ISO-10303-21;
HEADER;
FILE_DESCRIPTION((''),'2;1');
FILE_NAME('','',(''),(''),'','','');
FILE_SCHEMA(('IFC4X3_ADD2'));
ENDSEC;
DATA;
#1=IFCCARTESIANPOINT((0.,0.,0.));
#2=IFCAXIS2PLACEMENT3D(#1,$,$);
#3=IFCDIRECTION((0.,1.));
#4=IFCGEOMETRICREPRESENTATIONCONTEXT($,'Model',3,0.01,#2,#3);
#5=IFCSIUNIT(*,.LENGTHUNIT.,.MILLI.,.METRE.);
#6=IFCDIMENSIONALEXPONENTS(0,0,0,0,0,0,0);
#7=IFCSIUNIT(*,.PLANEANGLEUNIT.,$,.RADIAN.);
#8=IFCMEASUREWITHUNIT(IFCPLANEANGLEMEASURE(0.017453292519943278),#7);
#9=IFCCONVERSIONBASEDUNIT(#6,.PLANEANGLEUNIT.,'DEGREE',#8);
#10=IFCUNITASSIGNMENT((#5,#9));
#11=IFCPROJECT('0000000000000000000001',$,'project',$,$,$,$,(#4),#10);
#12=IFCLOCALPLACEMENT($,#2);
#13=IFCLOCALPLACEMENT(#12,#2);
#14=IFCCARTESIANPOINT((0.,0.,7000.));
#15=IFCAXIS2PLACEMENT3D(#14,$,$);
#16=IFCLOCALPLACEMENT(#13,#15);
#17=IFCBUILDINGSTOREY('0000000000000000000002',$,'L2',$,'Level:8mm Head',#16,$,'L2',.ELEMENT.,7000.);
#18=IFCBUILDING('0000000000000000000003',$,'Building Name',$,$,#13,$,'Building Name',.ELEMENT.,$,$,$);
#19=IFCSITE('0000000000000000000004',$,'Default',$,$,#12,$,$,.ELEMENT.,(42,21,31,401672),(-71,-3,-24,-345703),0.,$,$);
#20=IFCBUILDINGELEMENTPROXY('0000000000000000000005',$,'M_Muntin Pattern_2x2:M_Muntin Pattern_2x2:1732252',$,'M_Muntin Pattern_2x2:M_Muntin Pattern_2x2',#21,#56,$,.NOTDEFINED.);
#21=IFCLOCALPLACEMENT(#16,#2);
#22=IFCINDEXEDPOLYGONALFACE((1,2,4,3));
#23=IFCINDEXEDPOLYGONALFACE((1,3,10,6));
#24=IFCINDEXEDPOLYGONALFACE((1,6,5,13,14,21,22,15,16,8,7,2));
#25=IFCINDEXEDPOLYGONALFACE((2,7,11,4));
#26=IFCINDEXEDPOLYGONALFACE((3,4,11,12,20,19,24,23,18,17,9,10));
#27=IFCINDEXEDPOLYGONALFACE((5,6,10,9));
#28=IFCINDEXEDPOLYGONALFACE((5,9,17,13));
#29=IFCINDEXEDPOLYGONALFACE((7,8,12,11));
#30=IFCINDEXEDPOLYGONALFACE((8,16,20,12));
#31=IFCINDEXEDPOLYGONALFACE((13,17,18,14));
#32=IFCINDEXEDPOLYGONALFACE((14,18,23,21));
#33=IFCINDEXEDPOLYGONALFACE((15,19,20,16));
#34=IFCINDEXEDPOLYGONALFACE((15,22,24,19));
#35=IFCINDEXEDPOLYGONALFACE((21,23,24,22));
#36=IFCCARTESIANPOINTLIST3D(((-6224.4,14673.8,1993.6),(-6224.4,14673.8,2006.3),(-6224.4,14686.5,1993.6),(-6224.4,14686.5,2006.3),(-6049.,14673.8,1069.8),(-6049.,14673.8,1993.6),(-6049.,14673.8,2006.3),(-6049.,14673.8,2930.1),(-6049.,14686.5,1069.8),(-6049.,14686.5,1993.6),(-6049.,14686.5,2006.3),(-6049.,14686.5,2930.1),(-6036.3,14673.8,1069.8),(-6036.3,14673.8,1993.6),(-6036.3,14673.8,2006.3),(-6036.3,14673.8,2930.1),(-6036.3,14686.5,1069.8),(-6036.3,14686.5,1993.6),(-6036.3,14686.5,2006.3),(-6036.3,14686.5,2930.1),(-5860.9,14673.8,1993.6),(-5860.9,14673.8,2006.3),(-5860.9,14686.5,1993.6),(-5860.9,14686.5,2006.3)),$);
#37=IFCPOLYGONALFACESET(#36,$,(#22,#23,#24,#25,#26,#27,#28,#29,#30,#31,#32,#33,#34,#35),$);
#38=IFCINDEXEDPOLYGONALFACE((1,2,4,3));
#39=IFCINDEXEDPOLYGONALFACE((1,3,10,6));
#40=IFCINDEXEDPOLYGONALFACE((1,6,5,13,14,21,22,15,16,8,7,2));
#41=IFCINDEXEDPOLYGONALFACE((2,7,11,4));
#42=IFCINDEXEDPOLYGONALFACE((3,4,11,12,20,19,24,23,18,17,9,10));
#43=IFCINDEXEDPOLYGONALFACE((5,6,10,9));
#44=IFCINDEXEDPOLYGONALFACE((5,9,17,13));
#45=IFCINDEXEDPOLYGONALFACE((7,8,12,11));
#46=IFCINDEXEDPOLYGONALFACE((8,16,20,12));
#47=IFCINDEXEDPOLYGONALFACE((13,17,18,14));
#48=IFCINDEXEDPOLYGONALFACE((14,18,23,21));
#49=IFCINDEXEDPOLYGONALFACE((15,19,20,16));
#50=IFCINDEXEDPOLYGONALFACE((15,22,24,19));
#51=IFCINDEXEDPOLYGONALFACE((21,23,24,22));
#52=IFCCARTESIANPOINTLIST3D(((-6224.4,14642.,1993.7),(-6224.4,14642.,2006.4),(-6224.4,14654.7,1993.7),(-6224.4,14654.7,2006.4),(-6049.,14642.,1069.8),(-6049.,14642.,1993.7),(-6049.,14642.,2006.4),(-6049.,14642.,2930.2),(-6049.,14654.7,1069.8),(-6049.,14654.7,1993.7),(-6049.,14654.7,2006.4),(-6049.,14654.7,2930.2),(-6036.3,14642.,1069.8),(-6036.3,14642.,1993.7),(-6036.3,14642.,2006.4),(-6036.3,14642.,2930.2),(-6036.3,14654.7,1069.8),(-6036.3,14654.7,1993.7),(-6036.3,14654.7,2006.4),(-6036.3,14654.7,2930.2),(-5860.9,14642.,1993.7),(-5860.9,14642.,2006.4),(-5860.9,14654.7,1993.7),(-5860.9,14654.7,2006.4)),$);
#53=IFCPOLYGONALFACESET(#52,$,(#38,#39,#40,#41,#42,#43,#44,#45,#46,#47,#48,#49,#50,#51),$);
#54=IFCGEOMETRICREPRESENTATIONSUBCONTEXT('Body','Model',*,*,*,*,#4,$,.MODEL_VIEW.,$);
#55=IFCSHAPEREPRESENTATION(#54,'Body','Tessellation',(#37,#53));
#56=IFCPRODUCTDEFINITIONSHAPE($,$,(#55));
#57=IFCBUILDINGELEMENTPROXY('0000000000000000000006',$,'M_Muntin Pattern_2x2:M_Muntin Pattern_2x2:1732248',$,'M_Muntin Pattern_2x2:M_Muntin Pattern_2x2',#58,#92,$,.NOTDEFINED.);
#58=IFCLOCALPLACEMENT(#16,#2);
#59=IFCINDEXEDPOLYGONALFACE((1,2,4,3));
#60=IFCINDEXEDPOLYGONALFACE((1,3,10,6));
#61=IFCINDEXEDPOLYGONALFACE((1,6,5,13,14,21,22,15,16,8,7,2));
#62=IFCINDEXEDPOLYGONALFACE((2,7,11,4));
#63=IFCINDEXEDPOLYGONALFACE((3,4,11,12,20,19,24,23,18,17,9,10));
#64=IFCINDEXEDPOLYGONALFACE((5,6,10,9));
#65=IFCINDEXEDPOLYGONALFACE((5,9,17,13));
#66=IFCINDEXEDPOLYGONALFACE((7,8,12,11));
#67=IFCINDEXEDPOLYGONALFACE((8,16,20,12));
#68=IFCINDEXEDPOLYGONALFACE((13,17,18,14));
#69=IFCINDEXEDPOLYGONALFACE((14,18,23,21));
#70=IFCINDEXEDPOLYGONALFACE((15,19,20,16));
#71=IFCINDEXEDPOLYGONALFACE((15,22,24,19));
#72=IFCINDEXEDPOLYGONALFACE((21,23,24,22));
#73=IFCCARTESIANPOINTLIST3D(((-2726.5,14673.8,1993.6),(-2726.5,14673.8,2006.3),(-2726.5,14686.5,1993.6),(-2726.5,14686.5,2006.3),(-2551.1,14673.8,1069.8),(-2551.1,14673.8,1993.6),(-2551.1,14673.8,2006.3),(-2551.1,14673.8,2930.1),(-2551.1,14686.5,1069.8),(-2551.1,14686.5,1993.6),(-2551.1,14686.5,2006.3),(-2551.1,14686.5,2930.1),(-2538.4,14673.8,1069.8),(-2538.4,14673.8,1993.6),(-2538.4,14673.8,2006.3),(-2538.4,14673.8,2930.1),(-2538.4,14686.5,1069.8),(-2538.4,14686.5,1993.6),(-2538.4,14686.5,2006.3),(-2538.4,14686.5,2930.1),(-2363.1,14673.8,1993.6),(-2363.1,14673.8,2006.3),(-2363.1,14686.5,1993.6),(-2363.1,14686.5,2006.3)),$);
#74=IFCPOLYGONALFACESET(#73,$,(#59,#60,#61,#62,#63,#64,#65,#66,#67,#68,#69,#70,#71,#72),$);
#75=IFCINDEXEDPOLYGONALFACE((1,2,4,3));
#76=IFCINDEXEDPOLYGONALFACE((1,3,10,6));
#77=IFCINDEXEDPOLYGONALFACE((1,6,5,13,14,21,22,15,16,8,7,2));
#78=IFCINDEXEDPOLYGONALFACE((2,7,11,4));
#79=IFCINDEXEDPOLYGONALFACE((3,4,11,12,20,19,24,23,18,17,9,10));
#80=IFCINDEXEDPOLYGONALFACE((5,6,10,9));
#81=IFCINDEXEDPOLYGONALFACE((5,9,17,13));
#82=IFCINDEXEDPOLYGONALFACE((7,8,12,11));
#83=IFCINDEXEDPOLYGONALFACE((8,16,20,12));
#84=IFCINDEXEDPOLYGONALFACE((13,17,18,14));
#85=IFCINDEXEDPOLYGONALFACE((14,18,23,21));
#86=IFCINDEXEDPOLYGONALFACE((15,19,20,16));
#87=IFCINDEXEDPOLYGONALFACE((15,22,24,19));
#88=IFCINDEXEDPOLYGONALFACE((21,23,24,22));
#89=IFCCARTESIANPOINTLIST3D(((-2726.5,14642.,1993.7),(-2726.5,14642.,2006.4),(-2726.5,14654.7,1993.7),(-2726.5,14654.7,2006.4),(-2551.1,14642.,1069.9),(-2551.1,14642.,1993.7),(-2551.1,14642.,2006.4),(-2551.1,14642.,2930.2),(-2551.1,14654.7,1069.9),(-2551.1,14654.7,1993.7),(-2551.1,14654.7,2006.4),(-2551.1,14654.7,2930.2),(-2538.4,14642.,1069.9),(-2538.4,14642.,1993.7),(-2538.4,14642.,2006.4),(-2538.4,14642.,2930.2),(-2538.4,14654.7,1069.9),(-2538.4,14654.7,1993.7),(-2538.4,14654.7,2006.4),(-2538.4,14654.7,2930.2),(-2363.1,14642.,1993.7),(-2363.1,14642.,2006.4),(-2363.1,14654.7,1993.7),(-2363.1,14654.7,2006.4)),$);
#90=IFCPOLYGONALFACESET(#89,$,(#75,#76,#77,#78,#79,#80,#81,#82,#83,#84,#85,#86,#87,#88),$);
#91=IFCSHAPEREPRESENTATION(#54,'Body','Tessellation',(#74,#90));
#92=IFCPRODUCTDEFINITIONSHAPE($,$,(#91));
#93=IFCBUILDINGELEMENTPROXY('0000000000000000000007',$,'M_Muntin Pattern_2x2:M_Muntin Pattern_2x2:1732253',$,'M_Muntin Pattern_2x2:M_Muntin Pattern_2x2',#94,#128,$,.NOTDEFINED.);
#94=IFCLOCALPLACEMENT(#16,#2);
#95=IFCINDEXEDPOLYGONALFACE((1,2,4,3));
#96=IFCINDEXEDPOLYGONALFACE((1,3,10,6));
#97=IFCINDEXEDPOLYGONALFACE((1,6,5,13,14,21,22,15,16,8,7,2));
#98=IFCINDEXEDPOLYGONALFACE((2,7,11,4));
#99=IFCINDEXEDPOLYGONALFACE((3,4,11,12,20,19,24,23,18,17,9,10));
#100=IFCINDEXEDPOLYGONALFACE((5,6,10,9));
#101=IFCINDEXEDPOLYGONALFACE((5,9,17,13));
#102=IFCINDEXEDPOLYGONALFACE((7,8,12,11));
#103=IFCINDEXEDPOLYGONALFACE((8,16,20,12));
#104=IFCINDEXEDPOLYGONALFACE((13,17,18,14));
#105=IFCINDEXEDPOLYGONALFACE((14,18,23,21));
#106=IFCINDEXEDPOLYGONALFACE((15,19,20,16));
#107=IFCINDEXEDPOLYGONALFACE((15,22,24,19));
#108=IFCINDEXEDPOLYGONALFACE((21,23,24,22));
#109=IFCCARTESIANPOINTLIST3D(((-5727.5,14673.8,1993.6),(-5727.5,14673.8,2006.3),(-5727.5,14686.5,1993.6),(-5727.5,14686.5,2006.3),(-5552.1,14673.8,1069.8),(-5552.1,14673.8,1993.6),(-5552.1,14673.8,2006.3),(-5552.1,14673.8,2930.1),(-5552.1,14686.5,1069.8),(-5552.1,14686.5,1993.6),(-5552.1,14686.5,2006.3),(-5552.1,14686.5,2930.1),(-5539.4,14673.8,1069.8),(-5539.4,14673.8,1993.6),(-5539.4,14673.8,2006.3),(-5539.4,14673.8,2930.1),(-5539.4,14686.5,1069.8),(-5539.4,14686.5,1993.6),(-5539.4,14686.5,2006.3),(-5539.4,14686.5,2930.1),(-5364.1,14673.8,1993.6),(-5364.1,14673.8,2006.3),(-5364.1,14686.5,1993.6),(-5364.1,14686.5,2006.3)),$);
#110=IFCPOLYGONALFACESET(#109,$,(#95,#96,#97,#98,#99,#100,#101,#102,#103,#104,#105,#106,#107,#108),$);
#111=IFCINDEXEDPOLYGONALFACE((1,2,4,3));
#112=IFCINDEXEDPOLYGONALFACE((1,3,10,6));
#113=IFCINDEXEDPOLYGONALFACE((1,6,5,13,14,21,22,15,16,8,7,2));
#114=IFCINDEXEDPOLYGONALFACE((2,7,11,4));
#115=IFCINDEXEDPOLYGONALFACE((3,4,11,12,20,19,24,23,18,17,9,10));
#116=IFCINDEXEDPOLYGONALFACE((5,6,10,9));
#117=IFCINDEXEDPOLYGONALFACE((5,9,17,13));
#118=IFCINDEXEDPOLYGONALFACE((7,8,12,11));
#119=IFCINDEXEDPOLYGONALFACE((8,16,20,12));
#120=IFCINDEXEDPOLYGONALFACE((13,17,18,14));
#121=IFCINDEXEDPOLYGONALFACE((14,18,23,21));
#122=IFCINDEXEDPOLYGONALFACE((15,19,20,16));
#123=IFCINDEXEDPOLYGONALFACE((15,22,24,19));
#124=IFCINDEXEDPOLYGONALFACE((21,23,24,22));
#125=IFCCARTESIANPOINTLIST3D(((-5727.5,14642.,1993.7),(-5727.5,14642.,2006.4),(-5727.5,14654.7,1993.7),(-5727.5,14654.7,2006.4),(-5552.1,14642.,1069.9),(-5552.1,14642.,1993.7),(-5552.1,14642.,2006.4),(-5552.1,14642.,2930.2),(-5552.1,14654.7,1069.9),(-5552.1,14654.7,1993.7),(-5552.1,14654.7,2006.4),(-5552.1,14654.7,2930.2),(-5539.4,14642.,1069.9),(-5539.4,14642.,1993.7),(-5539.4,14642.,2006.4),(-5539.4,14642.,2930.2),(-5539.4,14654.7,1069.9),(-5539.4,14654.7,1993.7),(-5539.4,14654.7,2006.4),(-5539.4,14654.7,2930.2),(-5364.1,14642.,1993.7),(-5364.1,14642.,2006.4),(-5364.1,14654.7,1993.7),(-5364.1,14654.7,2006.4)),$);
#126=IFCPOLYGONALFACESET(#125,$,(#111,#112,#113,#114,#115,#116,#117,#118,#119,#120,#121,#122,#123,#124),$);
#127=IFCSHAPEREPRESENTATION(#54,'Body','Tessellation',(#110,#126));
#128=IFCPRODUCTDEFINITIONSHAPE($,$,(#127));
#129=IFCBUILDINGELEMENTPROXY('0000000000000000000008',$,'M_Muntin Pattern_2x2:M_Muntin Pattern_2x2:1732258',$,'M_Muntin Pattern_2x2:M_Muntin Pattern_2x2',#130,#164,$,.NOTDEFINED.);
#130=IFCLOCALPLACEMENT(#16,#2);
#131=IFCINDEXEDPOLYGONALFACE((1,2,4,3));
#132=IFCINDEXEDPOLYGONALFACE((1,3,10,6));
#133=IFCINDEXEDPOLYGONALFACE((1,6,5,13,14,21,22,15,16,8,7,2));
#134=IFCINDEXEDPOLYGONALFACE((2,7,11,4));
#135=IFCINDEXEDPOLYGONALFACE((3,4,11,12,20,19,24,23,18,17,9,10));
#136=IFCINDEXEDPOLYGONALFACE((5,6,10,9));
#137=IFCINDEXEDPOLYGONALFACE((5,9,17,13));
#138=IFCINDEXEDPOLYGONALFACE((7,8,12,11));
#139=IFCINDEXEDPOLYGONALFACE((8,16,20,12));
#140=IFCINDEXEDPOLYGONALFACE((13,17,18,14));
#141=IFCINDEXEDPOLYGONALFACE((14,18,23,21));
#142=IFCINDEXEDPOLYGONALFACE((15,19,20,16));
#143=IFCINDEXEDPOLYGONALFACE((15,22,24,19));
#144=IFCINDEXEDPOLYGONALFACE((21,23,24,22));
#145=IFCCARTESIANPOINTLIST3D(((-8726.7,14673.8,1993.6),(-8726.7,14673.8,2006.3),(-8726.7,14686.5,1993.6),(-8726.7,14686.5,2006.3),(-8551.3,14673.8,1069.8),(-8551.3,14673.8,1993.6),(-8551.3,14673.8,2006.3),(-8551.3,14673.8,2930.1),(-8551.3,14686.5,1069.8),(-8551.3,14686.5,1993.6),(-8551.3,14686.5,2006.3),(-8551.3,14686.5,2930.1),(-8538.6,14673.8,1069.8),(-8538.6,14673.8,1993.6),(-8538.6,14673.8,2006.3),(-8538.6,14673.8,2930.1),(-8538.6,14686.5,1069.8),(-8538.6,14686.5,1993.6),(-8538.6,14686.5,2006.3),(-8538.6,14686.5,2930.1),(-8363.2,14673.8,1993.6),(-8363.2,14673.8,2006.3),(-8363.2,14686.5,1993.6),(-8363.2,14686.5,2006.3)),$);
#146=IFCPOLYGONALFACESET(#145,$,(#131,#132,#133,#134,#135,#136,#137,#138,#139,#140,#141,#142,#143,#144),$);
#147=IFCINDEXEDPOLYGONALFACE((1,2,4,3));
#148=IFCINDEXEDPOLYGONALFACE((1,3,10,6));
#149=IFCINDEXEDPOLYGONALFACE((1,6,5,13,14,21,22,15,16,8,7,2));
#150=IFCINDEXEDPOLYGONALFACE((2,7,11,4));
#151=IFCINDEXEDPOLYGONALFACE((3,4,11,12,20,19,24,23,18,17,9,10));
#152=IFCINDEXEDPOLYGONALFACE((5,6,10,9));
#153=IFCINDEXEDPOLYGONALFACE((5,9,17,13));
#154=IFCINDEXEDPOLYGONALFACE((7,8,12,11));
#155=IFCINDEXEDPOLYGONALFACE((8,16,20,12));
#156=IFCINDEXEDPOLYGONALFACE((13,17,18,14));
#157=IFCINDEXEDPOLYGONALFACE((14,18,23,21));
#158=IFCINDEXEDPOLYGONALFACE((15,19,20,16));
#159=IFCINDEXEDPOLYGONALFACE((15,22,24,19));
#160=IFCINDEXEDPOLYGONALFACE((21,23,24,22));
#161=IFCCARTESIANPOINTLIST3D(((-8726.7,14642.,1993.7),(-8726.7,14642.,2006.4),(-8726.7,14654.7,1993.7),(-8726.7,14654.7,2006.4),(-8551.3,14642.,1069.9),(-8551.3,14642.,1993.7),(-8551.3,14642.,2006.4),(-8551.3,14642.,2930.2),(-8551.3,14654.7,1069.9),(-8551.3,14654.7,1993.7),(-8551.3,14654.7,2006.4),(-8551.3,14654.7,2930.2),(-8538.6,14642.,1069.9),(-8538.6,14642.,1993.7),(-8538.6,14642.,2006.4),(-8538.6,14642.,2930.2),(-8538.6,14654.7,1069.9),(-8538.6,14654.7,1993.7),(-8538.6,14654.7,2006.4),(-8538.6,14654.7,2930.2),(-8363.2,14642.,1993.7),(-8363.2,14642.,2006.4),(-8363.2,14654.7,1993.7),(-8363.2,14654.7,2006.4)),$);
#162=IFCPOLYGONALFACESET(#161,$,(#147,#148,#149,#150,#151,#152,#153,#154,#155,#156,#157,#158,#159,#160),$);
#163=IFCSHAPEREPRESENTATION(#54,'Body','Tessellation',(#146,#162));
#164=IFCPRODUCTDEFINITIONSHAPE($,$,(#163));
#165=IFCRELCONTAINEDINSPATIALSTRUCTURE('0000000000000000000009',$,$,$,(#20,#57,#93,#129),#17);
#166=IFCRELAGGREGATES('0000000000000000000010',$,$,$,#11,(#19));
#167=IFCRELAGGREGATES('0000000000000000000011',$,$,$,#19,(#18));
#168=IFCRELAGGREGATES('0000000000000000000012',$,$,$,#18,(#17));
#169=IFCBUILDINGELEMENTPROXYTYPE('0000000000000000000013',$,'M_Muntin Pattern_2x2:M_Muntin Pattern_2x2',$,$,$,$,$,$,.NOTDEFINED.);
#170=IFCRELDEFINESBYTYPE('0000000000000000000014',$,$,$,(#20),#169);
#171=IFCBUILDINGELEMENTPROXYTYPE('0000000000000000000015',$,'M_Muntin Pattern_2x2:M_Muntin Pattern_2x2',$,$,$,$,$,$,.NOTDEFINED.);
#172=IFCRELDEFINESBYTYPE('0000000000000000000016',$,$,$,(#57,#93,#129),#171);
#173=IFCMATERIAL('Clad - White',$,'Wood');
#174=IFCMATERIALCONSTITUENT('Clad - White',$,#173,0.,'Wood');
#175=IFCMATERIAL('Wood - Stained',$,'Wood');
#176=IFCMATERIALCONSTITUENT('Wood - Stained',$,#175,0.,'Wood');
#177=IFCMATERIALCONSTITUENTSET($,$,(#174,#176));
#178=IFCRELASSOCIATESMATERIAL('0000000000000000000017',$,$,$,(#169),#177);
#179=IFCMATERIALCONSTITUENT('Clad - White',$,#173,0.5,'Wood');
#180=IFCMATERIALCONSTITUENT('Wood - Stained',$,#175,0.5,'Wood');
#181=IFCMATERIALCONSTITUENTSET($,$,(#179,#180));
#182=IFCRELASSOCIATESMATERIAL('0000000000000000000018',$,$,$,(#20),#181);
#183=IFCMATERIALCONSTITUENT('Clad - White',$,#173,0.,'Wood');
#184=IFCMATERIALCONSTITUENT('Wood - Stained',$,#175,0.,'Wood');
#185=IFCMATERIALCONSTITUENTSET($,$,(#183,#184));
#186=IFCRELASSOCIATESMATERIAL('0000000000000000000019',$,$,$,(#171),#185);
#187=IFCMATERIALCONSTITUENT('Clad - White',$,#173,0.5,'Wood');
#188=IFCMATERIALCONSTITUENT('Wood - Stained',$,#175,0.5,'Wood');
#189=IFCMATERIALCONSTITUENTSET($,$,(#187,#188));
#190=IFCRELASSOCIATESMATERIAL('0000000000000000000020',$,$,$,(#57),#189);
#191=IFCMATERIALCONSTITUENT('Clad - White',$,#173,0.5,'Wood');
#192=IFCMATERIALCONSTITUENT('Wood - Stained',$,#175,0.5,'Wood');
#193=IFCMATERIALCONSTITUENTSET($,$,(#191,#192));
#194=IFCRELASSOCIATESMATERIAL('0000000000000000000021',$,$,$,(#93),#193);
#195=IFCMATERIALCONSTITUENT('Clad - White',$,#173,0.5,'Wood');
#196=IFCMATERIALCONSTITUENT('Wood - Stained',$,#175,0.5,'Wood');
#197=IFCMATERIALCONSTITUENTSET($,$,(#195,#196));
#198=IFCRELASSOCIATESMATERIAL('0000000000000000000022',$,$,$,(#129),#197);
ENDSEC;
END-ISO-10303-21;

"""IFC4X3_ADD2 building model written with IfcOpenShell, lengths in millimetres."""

from ifc_helpers import new_model, entity, si_unit, converted_unit, direction, frame, origin, place, context, subcontext, project, spatial, polyline, outline, extrude, source, transform, mapped, material, constituent, constituent_set, type_object, type_shapes, element, save


model = new_model("IFC4X3_ADD2")

# Units and contexts
model_context = context("Model", 3, precision=0.01, world=origin(), true_north=direction((0.0, 1.0)))
body_context = subcontext(model_context, "Body", "Model", "MODEL_VIEW")
ifc_project = project(units=[si_unit("LENGTHUNIT", "METRE", prefix="MILLI"), converted_unit("PLANEANGLEUNIT", "DEGREE", entity("IfcPlaneAngleMeasure", 0.017453292519943278), si_unit("PLANEANGLEUNIT", "RADIAN"), dimensions=[0, 0, 0, 0, 0, 0, 0])], contexts=[model_context])

# Site, building, storey
site_placement = place(None, origin())
site = spatial("IfcSite", under=ifc_project, at=site_placement, Name="Default", CompositionType="ELEMENT", RefLatitude=(42, 21, 31, 401672), RefLongitude=(-71, -3, -24, -345703), RefElevation=0.0)
building_placement = place(site_placement, origin())
building = spatial("IfcBuilding", under=site, at=building_placement, Name="Building Name", LongName="Building Name", CompositionType="ELEMENT")
storey_placement = place(building_placement, frame((0.0, 0.0, 7000.0)))
storey = spatial("IfcBuildingStorey", under=building, at=storey_placement, Name="L2", ObjectType="Level:8mm Head", LongName="L2", CompositionType="ELEMENT", Elevation=7000.0)

# Building element proxies
ifc_material_1 = material(Name="Clad - White", Category="Wood")
ifc_material_2 = material(Name="Wood - Stained", Category="Wood")
ifc_constituent_1 = constituent(ifc_material_1, Name="Clad - White", Category="Wood", fraction=0.0)
ifc_constituent_2 = constituent(ifc_material_2, Name="Wood - Stained", Category="Wood", fraction=0.0)
ifc_constituent_set_1 = constituent_set(constituents=[ifc_constituent_1, ifc_constituent_2])
building_element_proxy_type_1 = type_object("IfcBuildingElementProxyType", Name="M_Muntin Pattern_2x2:M_Muntin Pattern_2x2", PredefinedType="NOTDEFINED", material=ifc_constituent_set_1)
shared_shape_1 = source(origin(), body_context, "Body", "SweptSolid", [
    extrude(outline(polyline([(6.4, -6.4), (930.1, -6.4), (930.1, 6.3), (6.4, 6.3), (6.4, 181.7), (-6.3, 181.7), (-6.3, 6.3), (-930.2, 6.3), (-930.2, -6.4), (-6.3, -6.4), (-6.3, -181.7), (6.4, -181.7), (6.4, -6.4)])), frame((0.0, 9.5, 930.1), z_axis=(0.0, 1.0, 0.0), x_axis=(0.0, 0.0, 1.0)), (0.0, 0.0, 1.0), 12.7),
    extrude(outline(polyline([(6.4, -6.4), (930.2, -6.4), (930.2, 6.3), (6.4, 6.3), (6.4, 181.7), (-6.3, 181.7), (-6.3, 6.3), (-930.2, 6.3), (-930.2, -6.4), (-6.3, -6.4), (-6.3, -181.7), (6.4, -181.7), (6.4, -6.4)])), frame((0.0, -22.2, 930.2), z_axis=(0.0, 1.0, 0.0), x_axis=(0.0, 0.0, 1.0)), (0.0, 0.0, 1.0), 12.7),
])
type_shapes(building_element_proxy_type_1, [shared_shape_1])
ifc_constituent_3 = constituent(ifc_material_1, Name="Clad - White", Category="Wood", fraction=0.5)
ifc_constituent_4 = constituent(ifc_material_2, Name="Wood - Stained", Category="Wood", fraction=0.5)
ifc_constituent_set_2 = constituent_set(constituents=[ifc_constituent_3, ifc_constituent_4])
proxy_1_placement = place(storey_placement, frame((-6042.6, 14664.3, 1069.8)))
element("IfcBuildingElementProxy", 1, at=proxy_1_placement, inside=storey, type_object=building_element_proxy_type_1, material=ifc_constituent_set_2, Name="M_Muntin Pattern_2x2:M_Muntin Pattern_2x2:1732252", ObjectType="M_Muntin Pattern_2x2:M_Muntin Pattern_2x2", PredefinedType="NOTDEFINED", context=body_context, shape_type="MappedRepresentation", body=[
    mapped(shared_shape_1, transform((0.0, 0.0, 0.0), scale=1.0)),
])
ifc_constituent_5 = constituent(ifc_material_1, Name="Clad - White", Category="Wood", fraction=0.5)
ifc_constituent_6 = constituent(ifc_material_2, Name="Wood - Stained", Category="Wood", fraction=0.5)
ifc_constituent_set_3 = constituent_set(constituents=[ifc_constituent_5, ifc_constituent_6])
ifc_constituent_7 = constituent(ifc_material_1, Name="Clad - White", Category="Wood", fraction=0.0)
ifc_constituent_8 = constituent(ifc_material_2, Name="Wood - Stained", Category="Wood", fraction=0.0)
ifc_constituent_set_4 = constituent_set(constituents=[ifc_constituent_7, ifc_constituent_8])
building_element_proxy_type_2 = type_object("IfcBuildingElementProxyType", Name="M_Muntin Pattern_2x2:M_Muntin Pattern_2x2", PredefinedType="NOTDEFINED", material=ifc_constituent_set_4)
shared_shape_2 = source(origin(), body_context, "Body", "SweptSolid", [
    extrude(outline(polyline([(6.4, -6.4), (930.1, -6.4), (930.1, 6.3), (6.4, 6.3), (6.4, 181.7), (-6.3, 181.7), (-6.3, 6.3), (-930.2, 6.3), (-930.2, -6.4), (-6.3, -6.4), (-6.3, -181.7), (6.4, -181.7), (6.4, -6.4)])), frame((0.0, -22.2, 930.1), z_axis=(0.0, 1.0, 0.0), x_axis=(0.0, 0.0, 1.0)), (0.0, 0.0, 1.0), 12.7),
    extrude(outline(polyline([(6.4, -6.4), (930.2, -6.4), (930.2, 6.3), (6.4, 6.3), (6.4, 181.7), (-6.3, 181.7), (-6.3, 6.3), (-930.2, 6.3), (-930.2, -6.4), (-6.3, -6.4), (-6.3, -181.7), (6.4, -181.7), (6.4, -6.4)])), frame((0.0, 9.5, 930.2), z_axis=(0.0, 1.0, 0.0), x_axis=(0.0, 0.0, 1.0)), (0.0, 0.0, 1.0), 12.7),
])
type_shapes(building_element_proxy_type_2, [shared_shape_2])
proxy_2_placement = place(storey_placement, frame((-2544.8, 14664.3, 1069.9), z_axis=(0.0, 0.0, 1.0), x_axis=(-1.0, 0.0, 0.0)))
element("IfcBuildingElementProxy", 2, at=proxy_2_placement, inside=storey, type_object=building_element_proxy_type_2, material=ifc_constituent_set_3, Name="M_Muntin Pattern_2x2:M_Muntin Pattern_2x2:1732248", ObjectType="M_Muntin Pattern_2x2:M_Muntin Pattern_2x2", PredefinedType="NOTDEFINED", context=body_context, shape_type="MappedRepresentation", body=[
    mapped(shared_shape_2, transform((0.0, 0.0, 0.0), scale=1.0)),
])
ifc_constituent_9 = constituent(ifc_material_1, Name="Clad - White", Category="Wood", fraction=0.5)
ifc_constituent_10 = constituent(ifc_material_2, Name="Wood - Stained", Category="Wood", fraction=0.5)
ifc_constituent_set_5 = constituent_set(constituents=[ifc_constituent_9, ifc_constituent_10])
proxy_3_placement = place(storey_placement, frame((-5545.8, 14664.3, 1069.9), z_axis=(0.0, 0.0, 1.0), x_axis=(-1.0, 0.0, 0.0)))
element("IfcBuildingElementProxy", 3, at=proxy_3_placement, inside=storey, type_object=building_element_proxy_type_2, material=ifc_constituent_set_5, Name="M_Muntin Pattern_2x2:M_Muntin Pattern_2x2:1732253", ObjectType="M_Muntin Pattern_2x2:M_Muntin Pattern_2x2", PredefinedType="NOTDEFINED", context=body_context, shape_type="MappedRepresentation", body=[
    mapped(shared_shape_2, transform((0.0, 0.0, 0.0), scale=1.0)),
])
ifc_constituent_11 = constituent(ifc_material_1, Name="Clad - White", Category="Wood", fraction=0.5)
ifc_constituent_12 = constituent(ifc_material_2, Name="Wood - Stained", Category="Wood", fraction=0.5)
ifc_constituent_set_6 = constituent_set(constituents=[ifc_constituent_11, ifc_constituent_12])
proxy_4_placement = place(storey_placement, frame((-8544.9, 14664.3, 1069.9), z_axis=(0.0, 0.0, 1.0), x_axis=(-1.0, 0.0, 0.0)))
element("IfcBuildingElementProxy", 4, at=proxy_4_placement, inside=storey, type_object=building_element_proxy_type_2, material=ifc_constituent_set_6, Name="M_Muntin Pattern_2x2:M_Muntin Pattern_2x2:1732258", ObjectType="M_Muntin Pattern_2x2:M_Muntin Pattern_2x2", PredefinedType="NOTDEFINED", context=body_context, shape_type="MappedRepresentation", body=[
    mapped(shared_shape_2, transform((0.0, 0.0, 0.0), scale=1.0)),
])

save(model, "model.ifc")
